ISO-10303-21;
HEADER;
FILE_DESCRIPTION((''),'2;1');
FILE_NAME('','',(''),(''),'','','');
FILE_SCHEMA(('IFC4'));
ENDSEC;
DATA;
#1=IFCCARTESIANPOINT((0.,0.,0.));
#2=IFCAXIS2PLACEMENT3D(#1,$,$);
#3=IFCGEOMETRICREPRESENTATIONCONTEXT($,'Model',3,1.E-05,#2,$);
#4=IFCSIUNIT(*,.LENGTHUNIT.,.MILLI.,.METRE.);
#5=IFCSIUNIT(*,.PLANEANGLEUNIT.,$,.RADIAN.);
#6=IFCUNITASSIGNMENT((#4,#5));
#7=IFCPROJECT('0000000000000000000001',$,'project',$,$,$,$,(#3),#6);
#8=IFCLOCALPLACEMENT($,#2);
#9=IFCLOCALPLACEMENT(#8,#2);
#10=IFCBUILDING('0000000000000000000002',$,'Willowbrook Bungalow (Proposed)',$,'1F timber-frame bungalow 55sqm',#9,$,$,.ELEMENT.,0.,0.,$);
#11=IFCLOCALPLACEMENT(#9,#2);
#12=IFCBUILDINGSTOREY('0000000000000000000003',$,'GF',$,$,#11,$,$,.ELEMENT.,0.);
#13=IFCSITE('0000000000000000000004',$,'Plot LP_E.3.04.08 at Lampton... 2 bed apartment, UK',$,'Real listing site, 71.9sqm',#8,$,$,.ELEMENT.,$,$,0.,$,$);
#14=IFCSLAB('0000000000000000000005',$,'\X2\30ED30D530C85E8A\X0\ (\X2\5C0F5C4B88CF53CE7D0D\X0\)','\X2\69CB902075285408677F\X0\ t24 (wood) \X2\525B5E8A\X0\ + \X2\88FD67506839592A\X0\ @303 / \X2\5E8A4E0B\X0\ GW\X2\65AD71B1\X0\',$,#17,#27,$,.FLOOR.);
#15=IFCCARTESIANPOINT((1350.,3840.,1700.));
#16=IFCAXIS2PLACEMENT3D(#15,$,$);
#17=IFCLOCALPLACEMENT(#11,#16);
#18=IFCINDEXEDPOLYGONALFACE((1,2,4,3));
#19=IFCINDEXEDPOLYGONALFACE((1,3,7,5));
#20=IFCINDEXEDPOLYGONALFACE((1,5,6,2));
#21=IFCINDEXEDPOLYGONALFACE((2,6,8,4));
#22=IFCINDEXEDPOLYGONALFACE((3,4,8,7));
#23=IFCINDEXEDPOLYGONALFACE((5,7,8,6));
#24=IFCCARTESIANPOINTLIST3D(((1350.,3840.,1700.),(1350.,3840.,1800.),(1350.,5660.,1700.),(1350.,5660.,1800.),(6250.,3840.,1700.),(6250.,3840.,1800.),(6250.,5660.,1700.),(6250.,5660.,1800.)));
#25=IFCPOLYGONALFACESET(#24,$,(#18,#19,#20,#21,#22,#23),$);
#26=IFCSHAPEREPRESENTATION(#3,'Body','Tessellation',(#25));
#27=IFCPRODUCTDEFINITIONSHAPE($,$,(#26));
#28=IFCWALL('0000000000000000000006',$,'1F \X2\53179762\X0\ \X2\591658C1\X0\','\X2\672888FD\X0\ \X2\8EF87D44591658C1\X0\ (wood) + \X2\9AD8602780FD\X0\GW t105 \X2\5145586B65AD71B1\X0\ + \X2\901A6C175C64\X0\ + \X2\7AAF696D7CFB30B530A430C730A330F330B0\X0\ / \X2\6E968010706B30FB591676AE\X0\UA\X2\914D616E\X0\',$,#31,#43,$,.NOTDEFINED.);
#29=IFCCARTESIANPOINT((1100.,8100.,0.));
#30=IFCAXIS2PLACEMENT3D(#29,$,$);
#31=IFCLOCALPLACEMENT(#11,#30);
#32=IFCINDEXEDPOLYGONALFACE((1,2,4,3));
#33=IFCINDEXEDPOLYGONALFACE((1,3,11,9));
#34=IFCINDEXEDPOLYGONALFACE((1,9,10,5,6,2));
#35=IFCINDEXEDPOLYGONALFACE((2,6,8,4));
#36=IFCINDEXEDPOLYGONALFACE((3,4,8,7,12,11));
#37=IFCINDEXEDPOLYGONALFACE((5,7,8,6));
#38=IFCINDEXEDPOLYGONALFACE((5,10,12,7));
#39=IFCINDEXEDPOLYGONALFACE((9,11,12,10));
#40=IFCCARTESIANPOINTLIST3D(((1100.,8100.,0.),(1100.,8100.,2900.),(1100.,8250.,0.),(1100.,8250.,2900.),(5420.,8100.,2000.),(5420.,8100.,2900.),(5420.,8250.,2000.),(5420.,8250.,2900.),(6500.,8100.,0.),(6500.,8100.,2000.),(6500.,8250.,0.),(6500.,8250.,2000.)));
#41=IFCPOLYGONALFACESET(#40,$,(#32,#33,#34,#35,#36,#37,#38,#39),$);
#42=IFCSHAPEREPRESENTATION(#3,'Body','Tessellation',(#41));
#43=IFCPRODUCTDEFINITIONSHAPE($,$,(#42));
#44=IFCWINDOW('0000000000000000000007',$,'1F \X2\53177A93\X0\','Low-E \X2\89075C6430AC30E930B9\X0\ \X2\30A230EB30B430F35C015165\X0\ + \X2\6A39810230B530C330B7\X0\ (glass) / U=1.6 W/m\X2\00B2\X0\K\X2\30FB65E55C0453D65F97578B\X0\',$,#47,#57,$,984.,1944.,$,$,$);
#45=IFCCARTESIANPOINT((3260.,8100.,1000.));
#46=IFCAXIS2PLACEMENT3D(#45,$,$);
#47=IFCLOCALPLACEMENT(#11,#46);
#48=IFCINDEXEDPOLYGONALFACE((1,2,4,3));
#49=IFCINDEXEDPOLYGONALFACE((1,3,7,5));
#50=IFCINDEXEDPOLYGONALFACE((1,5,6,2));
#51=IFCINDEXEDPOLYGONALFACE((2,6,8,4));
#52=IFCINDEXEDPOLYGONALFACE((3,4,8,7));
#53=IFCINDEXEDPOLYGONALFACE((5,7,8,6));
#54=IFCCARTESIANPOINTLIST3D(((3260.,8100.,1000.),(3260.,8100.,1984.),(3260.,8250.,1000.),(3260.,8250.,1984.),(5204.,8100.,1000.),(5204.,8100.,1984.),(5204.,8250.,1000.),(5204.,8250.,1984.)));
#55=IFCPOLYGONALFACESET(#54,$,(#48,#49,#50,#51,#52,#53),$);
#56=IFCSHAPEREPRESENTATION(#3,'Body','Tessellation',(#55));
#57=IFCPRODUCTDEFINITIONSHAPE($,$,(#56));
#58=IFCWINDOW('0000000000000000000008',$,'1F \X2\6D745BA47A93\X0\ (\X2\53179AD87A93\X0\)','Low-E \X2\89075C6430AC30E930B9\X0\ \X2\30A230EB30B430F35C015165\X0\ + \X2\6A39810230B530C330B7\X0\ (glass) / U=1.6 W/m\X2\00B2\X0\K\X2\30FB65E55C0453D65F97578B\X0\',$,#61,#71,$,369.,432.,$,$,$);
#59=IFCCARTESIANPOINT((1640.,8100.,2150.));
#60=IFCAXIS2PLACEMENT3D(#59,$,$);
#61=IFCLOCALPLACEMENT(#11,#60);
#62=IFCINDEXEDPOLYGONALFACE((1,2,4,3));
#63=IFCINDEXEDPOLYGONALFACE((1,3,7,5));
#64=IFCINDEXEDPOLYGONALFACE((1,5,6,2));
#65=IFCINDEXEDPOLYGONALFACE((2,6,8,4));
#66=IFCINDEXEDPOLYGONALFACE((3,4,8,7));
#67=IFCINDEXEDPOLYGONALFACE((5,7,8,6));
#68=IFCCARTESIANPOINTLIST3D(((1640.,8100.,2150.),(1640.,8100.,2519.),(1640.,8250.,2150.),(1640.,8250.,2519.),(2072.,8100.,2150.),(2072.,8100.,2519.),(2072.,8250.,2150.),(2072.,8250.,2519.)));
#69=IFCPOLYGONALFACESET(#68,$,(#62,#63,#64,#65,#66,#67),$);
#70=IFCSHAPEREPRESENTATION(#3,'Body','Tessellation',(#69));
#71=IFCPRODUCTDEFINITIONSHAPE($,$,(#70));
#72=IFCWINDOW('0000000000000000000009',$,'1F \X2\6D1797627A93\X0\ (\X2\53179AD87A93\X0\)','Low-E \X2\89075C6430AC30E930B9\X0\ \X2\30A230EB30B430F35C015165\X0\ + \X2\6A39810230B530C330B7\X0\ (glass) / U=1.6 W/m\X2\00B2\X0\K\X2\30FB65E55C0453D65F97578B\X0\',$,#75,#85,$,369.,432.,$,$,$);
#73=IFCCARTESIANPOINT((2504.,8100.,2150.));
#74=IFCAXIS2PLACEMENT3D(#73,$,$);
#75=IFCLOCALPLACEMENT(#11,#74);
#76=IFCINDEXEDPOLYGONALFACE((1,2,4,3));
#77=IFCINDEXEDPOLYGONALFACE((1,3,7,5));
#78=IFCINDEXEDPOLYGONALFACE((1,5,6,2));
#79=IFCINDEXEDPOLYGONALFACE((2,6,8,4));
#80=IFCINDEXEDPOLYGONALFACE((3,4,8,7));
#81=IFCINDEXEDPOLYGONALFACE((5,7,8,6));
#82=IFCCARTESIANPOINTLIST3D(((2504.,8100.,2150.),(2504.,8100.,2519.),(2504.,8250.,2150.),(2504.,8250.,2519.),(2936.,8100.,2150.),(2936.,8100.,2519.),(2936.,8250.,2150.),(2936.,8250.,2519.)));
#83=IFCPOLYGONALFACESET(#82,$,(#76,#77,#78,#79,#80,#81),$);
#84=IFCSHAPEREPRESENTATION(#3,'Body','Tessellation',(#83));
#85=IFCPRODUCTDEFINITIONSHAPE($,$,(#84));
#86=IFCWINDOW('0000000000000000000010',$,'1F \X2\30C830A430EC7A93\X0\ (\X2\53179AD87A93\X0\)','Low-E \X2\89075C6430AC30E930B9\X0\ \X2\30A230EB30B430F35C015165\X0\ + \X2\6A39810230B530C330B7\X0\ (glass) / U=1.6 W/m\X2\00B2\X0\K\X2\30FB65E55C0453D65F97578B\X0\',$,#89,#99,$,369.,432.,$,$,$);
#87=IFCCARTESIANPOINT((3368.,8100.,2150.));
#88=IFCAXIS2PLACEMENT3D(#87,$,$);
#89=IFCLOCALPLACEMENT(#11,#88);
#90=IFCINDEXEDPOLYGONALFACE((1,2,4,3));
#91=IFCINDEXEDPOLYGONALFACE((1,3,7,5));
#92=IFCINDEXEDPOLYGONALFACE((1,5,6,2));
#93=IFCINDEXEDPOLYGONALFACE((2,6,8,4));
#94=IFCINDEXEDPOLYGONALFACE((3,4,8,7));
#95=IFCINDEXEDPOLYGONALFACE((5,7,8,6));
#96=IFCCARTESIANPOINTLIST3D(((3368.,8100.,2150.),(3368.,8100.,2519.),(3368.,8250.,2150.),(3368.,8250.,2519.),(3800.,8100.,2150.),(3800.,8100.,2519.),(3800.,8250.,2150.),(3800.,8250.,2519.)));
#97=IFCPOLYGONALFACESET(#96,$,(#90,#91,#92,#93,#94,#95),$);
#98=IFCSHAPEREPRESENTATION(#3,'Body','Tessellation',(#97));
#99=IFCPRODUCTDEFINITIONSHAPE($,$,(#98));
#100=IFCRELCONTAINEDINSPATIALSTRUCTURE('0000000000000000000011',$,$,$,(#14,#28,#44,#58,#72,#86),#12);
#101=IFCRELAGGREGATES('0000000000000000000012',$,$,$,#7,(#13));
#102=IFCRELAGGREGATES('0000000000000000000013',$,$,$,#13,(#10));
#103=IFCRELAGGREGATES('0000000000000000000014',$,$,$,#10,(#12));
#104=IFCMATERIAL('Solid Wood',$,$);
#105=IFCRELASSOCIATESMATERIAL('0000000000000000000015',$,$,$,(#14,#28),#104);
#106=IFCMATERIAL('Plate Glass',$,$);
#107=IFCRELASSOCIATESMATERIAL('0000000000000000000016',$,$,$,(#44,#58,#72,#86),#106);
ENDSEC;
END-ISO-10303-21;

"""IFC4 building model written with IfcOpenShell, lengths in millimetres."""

from ifc_helpers import new_model, si_unit, frame, frame_2d, origin, place, context, project, spatial, rectangle, extrude, material, element, fill, save


model = new_model("IFC4")

# Units and contexts
model_context = context("Model", 3, precision=1e-05, world=origin())
ifc_project = project(units=[si_unit("LENGTHUNIT", "METRE", prefix="MILLI"), si_unit("PLANEANGLEUNIT", "RADIAN")], contexts=[model_context])

# Site, building, storey
site_placement = place(None, origin())
site = spatial("IfcSite", under=ifc_project, at=site_placement, Name="Plot LP_E.3.04.08 at Lampton... 2 bed apartment, UK", ObjectType="Real listing site, 71.9sqm", CompositionType="ELEMENT", RefElevation=0.0)
building_placement = place(site_placement, origin())
building = spatial("IfcBuilding", under=site, at=building_placement, Name="Willowbrook Bungalow (Proposed)", ObjectType="1F timber-frame bungalow 55sqm", CompositionType="ELEMENT", ElevationOfRefHeight=0.0, ElevationOfTerrain=0.0)
storey_placement = place(building_placement, origin())
storey = spatial("IfcBuildingStorey", under=building, at=storey_placement, Name="GF", CompositionType="ELEMENT", Elevation=0.0)

# Slab
ifc_material_1 = material(Name="Solid Wood")
slab_placement = place(storey_placement, frame((1350.0, 3840.0, 1700.0)))
element("IfcSlab", 1, at=slab_placement, inside=storey, material=ifc_material_1, Name="ロフト床 (小屋裏収納)", Description="構造用合板 t24 (wood) 剛床 + 製材根太 @303 / 床下 GW断熱", PredefinedType="FLOOR", context=model_context, shape_type="SweptSolid", body=[
    extrude(rectangle(XDim=4900.0, YDim=1820.0, at=frame_2d((2450.0, 910.0))), frame((1350.0, 3840.0, 1700.0)), (0.0, 0.0, 1.0), 100.0),
])

# Wall, openings, windows
wall_1_placement = place(storey_placement, frame((1100.0, 8100.0, 0.0)))
wall_1 = element("IfcWall", 2, at=wall_1_placement, inside=storey, material=ifc_material_1, Name="1F 北面 外壁", Description="木製 軸組外壁 (wood) + 高性能GW t105 充填断熱 + 通気層 + 窯業系サイディング / 準耐火・外皮UA配慮", PredefinedType="NOTDEFINED", context=model_context, shape_type="SweptSolid", body=[
    extrude(rectangle(XDim=5400.0, YDim=150.0, at=frame_2d((2700.0, 75.0))), frame((1100.0, 8100.0, 0.0)), (0.0, 0.0, 1.0), 2900.0),
])
opening_1_placement = place(storey_placement, frame((3260.0, 8100.0, 1000.0)))
opening_1 = element("IfcOpeningElement", 3, at=opening_1_placement, cuts=wall_1, PredefinedType="NOTDEFINED", context=model_context, shape_type="SweptSolid", body=[
    extrude(rectangle(XDim=1944.0, YDim=150.0, at=frame_2d((972.0, 75.0))), frame((3260.0, 8100.0, 1000.0)), (0.0, 0.0, 1.0), 984.0),
])
opening_2_placement = place(storey_placement, frame((1640.0, 8100.0, 2150.0)))
opening_2 = element("IfcOpeningElement", 4, at=opening_2_placement, cuts=wall_1, PredefinedType="NOTDEFINED", context=model_context, shape_type="SweptSolid", body=[
    extrude(rectangle(XDim=432.0, YDim=150.0, at=frame_2d((216.0, 75.0))), frame((1640.0, 8100.0, 2150.0)), (0.0, 0.0, 1.0), 369.0),
])
opening_3_placement = place(storey_placement, frame((2504.0, 8100.0, 2150.0)))
opening_3 = element("IfcOpeningElement", 5, at=opening_3_placement, cuts=wall_1, PredefinedType="NOTDEFINED", context=model_context, shape_type="SweptSolid", body=[
    extrude(rectangle(XDim=432.0, YDim=150.0, at=frame_2d((216.0, 75.0))), frame((2504.0, 8100.0, 2150.0)), (0.0, 0.0, 1.0), 369.0),
])
opening_4_placement = place(storey_placement, frame((3368.0, 8100.0, 2150.0)))
opening_4 = element("IfcOpeningElement", 6, at=opening_4_placement, cuts=wall_1, PredefinedType="NOTDEFINED", context=model_context, shape_type="SweptSolid", body=[
    extrude(rectangle(XDim=432.0, YDim=150.0, at=frame_2d((216.0, 75.0))), frame((3368.0, 8100.0, 2150.0)), (0.0, 0.0, 1.0), 369.0),
])
ifc_material_2 = material(Name="Plate Glass")
window_1_placement = place(storey_placement, frame((3260.0, 8100.0, 1000.0)))
window_1 = element("IfcWindow", 7, at=window_1_placement, inside=storey, material=ifc_material_2, Name="1F 北窓", Description="Low-E 複層ガラス アルゴン封入 + 樹脂サッシ (glass) / U=1.6 W/m²K・日射取得型", OverallHeight=984.0, OverallWidth=1944.0, context=model_context, shape_type="SweptSolid", body=[
    extrude(rectangle(XDim=1944.0, YDim=150.0, at=frame_2d((972.0, 75.0))), frame((3260.0, 8100.0, 1000.0)), (0.0, 0.0, 1.0), 984.0),
])
fill(opening_1, window_1)
window_2_placement = place(storey_placement, frame((1640.0, 8100.0, 2150.0)))
window_2 = element("IfcWindow", 8, at=window_2_placement, inside=storey, material=ifc_material_2, Name="1F 浴室窓 (北高窓)", Description="Low-E 複層ガラス アルゴン封入 + 樹脂サッシ (glass) / U=1.6 W/m²K・日射取得型", OverallHeight=369.0, OverallWidth=432.0, context=model_context, shape_type="SweptSolid", body=[
    extrude(rectangle(XDim=432.0, YDim=150.0, at=frame_2d((216.0, 75.0))), frame((1640.0, 8100.0, 2150.0)), (0.0, 0.0, 1.0), 369.0),
])
fill(opening_2, window_2)
window_3_placement = place(storey_placement, frame((2504.0, 8100.0, 2150.0)))
window_3 = element("IfcWindow", 9, at=window_3_placement, inside=storey, material=ifc_material_2, Name="1F 洗面窓 (北高窓)", Description="Low-E 複層ガラス アルゴン封入 + 樹脂サッシ (glass) / U=1.6 W/m²K・日射取得型", OverallHeight=369.0, OverallWidth=432.0, context=model_context, shape_type="SweptSolid", body=[
    extrude(rectangle(XDim=432.0, YDim=150.0, at=frame_2d((216.0, 75.0))), frame((2504.0, 8100.0, 2150.0)), (0.0, 0.0, 1.0), 369.0),
])
fill(opening_3, window_3)
window_4_placement = place(storey_placement, frame((3368.0, 8100.0, 2150.0)))
window_4 = element("IfcWindow", 10, at=window_4_placement, inside=storey, material=ifc_material_2, Name="1F トイレ窓 (北高窓)", Description="Low-E 複層ガラス アルゴン封入 + 樹脂サッシ (glass) / U=1.6 W/m²K・日射取得型", OverallHeight=369.0, OverallWidth=432.0, context=model_context, shape_type="SweptSolid", body=[
    extrude(rectangle(XDim=432.0, YDim=150.0, at=frame_2d((216.0, 75.0))), frame((3368.0, 8100.0, 2150.0)), (0.0, 0.0, 1.0), 369.0),
])
fill(opening_4, window_4)

save(model, "model.ifc")
